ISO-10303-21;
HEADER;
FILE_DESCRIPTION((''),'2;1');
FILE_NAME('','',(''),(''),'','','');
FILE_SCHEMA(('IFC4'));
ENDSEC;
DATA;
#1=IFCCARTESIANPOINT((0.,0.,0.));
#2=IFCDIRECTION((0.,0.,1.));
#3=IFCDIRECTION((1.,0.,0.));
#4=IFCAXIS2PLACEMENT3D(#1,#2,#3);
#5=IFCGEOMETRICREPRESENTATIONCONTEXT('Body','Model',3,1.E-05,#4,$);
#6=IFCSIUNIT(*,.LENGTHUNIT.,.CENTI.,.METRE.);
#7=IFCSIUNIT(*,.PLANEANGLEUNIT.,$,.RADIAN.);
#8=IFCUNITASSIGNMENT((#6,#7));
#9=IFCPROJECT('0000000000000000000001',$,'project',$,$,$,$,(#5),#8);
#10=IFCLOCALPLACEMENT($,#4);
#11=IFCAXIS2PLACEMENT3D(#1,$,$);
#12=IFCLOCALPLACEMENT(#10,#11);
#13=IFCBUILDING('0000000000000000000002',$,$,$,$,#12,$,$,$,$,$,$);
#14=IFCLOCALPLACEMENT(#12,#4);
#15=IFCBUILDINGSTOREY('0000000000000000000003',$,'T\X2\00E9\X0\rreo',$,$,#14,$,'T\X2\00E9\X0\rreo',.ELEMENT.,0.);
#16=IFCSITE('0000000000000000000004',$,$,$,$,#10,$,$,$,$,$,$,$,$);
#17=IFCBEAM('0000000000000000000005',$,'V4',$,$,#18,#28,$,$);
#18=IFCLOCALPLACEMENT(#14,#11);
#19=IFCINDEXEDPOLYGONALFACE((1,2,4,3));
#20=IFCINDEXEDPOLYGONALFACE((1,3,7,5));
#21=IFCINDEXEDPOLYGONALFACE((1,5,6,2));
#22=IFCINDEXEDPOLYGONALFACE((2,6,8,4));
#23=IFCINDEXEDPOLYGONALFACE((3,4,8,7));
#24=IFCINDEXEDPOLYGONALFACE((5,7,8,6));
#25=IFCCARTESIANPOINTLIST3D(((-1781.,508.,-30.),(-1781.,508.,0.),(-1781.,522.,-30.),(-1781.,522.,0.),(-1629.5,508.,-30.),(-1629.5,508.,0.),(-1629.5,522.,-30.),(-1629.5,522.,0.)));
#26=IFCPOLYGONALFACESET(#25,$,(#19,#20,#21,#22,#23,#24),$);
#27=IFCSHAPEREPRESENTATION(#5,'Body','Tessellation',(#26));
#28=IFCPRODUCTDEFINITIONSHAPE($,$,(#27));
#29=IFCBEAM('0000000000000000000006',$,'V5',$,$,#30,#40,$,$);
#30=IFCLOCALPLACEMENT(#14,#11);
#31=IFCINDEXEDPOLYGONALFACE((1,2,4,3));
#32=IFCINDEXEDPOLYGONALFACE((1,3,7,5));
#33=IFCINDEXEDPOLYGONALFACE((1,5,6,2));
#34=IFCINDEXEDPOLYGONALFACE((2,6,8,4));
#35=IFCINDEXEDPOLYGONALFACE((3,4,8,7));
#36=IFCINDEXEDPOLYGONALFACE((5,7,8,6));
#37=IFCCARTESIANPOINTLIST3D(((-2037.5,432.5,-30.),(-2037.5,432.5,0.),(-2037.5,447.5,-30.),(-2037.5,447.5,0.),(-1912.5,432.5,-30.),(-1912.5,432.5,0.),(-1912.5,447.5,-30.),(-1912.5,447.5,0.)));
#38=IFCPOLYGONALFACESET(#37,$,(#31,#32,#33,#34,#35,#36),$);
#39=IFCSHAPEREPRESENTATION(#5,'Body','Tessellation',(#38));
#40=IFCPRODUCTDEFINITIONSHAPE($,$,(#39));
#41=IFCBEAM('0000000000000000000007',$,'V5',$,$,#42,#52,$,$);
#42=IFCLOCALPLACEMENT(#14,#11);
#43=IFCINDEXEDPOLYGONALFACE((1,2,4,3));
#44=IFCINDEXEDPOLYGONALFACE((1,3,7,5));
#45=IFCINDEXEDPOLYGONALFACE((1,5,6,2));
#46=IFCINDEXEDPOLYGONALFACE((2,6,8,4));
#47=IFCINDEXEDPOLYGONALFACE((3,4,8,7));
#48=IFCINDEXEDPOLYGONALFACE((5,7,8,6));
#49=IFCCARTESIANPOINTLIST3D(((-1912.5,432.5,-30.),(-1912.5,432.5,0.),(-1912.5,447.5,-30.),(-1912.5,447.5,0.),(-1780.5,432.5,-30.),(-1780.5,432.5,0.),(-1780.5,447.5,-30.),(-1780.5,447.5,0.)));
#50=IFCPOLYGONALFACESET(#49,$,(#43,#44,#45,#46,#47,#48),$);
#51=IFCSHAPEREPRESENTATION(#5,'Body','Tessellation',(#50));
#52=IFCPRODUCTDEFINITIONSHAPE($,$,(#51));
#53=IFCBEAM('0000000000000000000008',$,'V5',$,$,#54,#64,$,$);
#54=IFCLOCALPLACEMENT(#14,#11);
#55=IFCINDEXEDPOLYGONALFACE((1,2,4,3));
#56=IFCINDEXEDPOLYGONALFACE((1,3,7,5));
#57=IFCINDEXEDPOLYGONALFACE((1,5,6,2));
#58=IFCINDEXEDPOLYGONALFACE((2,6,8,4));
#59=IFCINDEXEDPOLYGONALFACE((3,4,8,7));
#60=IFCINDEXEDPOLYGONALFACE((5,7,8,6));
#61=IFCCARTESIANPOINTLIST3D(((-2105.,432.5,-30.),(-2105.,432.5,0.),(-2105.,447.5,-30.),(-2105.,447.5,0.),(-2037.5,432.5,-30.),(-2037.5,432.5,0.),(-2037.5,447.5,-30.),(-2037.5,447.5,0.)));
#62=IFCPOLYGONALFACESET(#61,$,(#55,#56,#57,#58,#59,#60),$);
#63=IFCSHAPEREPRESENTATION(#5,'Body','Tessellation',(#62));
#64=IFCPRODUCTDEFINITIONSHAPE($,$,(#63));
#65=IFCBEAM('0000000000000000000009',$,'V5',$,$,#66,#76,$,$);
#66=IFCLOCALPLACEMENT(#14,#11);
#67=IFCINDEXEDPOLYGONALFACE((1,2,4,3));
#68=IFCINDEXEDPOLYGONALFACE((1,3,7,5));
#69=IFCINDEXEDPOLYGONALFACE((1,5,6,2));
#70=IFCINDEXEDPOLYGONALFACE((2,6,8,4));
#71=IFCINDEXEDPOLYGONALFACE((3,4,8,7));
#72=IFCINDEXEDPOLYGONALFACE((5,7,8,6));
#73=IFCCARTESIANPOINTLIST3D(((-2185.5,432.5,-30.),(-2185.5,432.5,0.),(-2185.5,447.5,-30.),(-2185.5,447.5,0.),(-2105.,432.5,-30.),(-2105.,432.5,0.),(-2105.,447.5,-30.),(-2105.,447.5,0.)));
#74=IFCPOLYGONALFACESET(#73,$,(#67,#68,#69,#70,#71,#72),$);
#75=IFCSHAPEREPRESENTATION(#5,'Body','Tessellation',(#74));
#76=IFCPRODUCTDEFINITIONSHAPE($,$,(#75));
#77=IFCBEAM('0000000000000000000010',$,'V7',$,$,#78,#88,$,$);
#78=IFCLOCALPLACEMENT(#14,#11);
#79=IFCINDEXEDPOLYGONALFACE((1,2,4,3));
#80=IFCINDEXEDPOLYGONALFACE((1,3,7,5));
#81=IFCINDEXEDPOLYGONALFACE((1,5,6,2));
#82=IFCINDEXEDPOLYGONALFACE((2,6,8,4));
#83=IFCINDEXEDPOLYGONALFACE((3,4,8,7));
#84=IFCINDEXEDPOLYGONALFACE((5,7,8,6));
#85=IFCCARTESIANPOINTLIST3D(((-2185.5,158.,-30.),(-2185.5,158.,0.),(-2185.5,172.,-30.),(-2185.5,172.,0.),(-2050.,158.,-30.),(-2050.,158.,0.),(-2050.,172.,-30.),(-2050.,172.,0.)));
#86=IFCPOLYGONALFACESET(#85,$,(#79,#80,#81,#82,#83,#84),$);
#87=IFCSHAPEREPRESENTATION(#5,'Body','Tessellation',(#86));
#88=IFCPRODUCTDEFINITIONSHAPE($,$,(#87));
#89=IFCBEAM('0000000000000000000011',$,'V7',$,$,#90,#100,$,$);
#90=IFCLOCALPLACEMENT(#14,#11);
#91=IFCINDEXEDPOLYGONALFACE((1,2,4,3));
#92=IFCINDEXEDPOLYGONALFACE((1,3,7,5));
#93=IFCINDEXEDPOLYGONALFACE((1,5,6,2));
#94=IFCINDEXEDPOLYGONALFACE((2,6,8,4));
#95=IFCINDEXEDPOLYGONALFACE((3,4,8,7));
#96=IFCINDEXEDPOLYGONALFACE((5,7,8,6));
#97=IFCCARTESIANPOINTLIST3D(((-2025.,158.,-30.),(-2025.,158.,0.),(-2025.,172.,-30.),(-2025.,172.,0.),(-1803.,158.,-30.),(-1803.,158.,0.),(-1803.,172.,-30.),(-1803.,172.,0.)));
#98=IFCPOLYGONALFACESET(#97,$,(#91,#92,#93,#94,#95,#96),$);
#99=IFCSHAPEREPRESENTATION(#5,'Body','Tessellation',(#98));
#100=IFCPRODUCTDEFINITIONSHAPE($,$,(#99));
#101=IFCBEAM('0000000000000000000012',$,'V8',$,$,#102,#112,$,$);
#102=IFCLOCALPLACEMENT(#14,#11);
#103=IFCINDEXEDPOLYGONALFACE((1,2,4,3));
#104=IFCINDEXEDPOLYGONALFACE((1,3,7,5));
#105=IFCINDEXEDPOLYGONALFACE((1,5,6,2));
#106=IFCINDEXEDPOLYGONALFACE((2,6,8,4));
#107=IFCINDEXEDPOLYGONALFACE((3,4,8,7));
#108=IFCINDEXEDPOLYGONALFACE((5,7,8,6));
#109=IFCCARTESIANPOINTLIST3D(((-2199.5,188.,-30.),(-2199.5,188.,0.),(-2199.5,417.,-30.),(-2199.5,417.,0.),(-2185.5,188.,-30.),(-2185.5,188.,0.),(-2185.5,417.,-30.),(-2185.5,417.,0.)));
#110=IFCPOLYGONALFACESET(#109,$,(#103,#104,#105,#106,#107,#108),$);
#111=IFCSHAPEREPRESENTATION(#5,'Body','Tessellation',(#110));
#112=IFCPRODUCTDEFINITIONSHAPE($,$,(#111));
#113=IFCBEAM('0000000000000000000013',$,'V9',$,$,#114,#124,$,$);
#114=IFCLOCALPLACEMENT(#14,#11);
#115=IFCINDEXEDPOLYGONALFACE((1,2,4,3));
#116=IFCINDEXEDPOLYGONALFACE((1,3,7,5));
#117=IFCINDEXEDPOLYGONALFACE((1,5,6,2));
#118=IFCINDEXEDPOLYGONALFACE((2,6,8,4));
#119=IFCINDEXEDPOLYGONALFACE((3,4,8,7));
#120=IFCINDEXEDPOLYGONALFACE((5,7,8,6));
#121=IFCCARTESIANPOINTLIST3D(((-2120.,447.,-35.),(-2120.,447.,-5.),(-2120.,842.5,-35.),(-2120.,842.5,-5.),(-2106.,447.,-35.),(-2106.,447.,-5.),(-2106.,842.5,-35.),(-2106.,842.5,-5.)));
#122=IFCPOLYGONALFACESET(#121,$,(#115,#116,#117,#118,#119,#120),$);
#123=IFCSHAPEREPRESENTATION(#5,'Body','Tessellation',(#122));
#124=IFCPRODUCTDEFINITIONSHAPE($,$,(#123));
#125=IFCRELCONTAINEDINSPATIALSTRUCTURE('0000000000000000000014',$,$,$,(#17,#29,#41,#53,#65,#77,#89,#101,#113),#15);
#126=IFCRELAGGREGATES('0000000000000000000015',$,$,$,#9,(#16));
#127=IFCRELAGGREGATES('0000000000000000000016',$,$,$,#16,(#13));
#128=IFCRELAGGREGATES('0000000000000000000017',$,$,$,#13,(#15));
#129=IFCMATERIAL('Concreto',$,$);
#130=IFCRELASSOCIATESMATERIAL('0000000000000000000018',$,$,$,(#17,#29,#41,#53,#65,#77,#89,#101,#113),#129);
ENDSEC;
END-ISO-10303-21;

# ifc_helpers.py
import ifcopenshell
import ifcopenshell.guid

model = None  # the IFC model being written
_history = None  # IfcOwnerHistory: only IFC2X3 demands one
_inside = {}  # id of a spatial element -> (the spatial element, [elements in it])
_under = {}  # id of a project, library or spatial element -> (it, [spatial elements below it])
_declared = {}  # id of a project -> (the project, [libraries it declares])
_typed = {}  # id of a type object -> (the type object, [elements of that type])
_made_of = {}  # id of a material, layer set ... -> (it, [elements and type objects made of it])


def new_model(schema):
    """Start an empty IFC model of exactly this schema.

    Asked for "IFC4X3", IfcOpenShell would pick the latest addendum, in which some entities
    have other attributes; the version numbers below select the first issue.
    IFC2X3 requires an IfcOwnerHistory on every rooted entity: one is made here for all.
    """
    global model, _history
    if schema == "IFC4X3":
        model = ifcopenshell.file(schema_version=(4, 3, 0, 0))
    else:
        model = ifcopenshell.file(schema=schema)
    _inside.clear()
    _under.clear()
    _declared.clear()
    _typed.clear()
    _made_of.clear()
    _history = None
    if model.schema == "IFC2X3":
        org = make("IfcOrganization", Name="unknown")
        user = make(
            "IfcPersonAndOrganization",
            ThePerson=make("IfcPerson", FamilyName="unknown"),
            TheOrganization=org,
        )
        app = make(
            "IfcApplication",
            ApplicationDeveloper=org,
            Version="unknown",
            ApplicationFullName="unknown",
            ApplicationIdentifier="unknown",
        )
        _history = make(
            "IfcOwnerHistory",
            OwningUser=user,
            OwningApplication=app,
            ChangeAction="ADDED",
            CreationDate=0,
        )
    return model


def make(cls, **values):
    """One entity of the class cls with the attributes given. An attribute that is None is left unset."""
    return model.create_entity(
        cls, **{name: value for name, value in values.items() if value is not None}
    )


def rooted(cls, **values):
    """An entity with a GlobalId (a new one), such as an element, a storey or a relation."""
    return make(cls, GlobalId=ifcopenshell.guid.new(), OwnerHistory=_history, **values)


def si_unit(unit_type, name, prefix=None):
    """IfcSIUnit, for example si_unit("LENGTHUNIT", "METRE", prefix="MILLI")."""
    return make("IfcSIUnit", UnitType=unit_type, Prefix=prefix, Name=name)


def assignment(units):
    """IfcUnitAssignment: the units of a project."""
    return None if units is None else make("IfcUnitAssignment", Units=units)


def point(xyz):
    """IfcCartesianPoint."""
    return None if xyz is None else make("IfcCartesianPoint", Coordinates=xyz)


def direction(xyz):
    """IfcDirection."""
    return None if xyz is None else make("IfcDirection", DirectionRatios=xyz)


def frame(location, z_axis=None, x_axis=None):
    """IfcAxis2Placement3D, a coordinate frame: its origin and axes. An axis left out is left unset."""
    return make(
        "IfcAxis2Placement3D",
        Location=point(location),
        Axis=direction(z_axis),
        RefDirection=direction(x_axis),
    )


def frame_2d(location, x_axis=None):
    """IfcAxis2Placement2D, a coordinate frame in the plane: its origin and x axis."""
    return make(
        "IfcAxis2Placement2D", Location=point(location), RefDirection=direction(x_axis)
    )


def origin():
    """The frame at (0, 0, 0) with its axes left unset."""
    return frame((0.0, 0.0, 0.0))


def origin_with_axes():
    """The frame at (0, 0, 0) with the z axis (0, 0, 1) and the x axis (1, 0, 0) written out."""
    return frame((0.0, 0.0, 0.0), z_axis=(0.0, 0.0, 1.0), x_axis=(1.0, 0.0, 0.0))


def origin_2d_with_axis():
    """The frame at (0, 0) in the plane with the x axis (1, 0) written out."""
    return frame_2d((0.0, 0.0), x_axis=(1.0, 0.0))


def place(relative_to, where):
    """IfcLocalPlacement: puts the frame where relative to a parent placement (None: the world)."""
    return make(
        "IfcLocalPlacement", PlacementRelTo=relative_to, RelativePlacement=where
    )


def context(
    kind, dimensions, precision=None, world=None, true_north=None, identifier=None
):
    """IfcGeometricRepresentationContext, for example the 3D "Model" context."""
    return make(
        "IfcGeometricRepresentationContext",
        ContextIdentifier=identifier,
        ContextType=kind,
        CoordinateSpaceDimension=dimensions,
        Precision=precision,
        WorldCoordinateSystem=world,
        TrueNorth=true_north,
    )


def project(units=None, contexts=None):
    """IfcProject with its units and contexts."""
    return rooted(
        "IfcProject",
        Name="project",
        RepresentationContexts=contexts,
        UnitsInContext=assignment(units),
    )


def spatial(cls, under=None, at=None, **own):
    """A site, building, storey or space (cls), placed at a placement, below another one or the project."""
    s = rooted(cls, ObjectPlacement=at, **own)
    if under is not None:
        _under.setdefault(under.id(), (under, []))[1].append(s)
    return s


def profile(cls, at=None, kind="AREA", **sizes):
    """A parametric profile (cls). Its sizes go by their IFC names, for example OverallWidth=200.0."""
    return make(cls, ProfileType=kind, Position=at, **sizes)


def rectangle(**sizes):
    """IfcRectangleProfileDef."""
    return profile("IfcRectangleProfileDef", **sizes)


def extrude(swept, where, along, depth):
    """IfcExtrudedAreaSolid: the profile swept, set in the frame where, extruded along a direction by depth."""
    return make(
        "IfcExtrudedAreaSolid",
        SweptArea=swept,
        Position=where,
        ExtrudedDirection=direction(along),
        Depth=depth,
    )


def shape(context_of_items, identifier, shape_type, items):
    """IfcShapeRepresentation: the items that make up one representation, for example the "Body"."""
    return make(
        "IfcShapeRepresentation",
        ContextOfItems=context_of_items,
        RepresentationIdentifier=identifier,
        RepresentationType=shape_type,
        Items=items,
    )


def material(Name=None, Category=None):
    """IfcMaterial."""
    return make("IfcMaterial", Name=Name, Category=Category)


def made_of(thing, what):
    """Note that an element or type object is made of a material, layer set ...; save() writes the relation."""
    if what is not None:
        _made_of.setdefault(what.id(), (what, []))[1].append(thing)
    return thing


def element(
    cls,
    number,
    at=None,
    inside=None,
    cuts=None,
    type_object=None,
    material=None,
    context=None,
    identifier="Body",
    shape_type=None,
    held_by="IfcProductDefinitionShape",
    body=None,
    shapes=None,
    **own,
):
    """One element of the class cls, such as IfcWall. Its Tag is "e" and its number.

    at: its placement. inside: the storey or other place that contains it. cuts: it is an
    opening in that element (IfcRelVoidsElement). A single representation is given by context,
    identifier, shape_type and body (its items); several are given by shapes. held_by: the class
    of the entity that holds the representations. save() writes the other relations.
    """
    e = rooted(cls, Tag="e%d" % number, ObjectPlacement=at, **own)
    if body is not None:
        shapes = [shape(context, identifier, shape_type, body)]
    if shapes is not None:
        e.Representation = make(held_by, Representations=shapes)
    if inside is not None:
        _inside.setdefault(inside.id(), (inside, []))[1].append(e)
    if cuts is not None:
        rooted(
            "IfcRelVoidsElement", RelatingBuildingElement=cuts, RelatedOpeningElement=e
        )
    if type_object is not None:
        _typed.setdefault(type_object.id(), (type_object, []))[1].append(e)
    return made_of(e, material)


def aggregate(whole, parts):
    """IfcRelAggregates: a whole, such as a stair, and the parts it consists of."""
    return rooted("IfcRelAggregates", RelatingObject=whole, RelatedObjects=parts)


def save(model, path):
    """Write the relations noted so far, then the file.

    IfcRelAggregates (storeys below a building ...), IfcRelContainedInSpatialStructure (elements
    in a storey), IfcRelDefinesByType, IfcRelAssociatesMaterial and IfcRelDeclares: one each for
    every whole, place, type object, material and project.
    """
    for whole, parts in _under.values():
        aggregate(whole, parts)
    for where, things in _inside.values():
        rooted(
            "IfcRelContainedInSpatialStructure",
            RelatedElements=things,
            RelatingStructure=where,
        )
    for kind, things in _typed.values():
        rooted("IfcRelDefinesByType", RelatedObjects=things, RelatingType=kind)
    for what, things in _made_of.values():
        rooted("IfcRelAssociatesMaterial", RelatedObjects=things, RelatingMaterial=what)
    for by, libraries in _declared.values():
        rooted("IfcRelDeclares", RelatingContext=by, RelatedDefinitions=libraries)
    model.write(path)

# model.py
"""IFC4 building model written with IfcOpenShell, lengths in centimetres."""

from ifc_helpers import new_model, si_unit, frame, origin, origin_with_axes, origin_2d_with_axis, place, context, project, spatial, rectangle, extrude, material, element, save


model = new_model("IFC4")

# Units and contexts
model_context = context("Model", 3, precision=1e-05, world=origin_with_axes(), identifier="Body")
ifc_project = project(units=[si_unit("LENGTHUNIT", "METRE", prefix="CENTI"), si_unit("PLANEANGLEUNIT", "RADIAN")], contexts=[model_context])

# Site, building, storey
site_placement = place(None, origin_with_axes())
site = spatial("IfcSite", under=ifc_project, at=site_placement)
building_placement = place(site_placement, origin())
building = spatial("IfcBuilding", under=site, at=building_placement)
storey_placement = place(building_placement, origin_with_axes())
storey = spatial("IfcBuildingStorey", under=building, at=storey_placement, Name="Térreo", LongName="Térreo", CompositionType="ELEMENT", Elevation=0.0)

# Shared definitions
ifc_material = material(Name="Concreto")

# Beams
beam_1_placement = place(storey_placement, frame((-1705.25, 515.0, 0.0), z_axis=(0.0, 0.0, 1.0), x_axis=(1.0, 0.0, 0.0)))
element("IfcBeam", 1, at=beam_1_placement, inside=storey, material=ifc_material, Name="V4", context=model_context, shape_type="SolidModel", body=[
    extrude(rectangle(XDim=14.0, YDim=30.0, at=origin_2d_with_axis()), frame((-75.75, 0.0, -15.0), z_axis=(1.0, 0.0, 0.0), x_axis=(0.0, -1.0, 0.0)), (0.0, 0.0, 1.0), 151.5),
])
beam_2_placement = place(storey_placement, frame((-1975.0, 440.0, 0.0), z_axis=(0.0, 0.0, 1.0), x_axis=(1.0, 0.0, 0.0)))
element("IfcBeam", 2, at=beam_2_placement, inside=storey, material=ifc_material, Name="V5", context=model_context, shape_type="SolidModel", body=[
    extrude(rectangle(XDim=15.0, YDim=30.0, at=origin_2d_with_axis()), frame((-62.5, 0.0, -15.0), z_axis=(1.0, 0.0, 0.0), x_axis=(0.0, -1.0, 0.0)), (0.0, 0.0, 1.0), 125.0),
])
beam_3_placement = place(storey_placement, frame((-1846.5, 440.0, 0.0), z_axis=(0.0, 0.0, 1.0), x_axis=(1.0, 0.0, 0.0)))
element("IfcBeam", 3, at=beam_3_placement, inside=storey, material=ifc_material, Name="V5", context=model_context, shape_type="SolidModel", body=[
    extrude(rectangle(XDim=15.0, YDim=30.0, at=origin_2d_with_axis()), frame((-66.0, 0.0, -15.0), z_axis=(1.0, 0.0, 0.0), x_axis=(0.0, -1.0, 0.0)), (0.0, 0.0, 1.0), 132.0),
])
beam_4_placement = place(storey_placement, frame((-2071.25, 440.0, 0.0), z_axis=(0.0, 0.0, 1.0), x_axis=(1.0, 0.0, 0.0)))
element("IfcBeam", 4, at=beam_4_placement, inside=storey, material=ifc_material, Name="V5", context=model_context, shape_type="SolidModel", body=[
    extrude(rectangle(XDim=15.0, YDim=30.0, at=origin_2d_with_axis()), frame((-33.75, 0.0, -15.0), z_axis=(1.0, 0.0, 0.0), x_axis=(0.0, -1.0, 0.0)), (0.0, 0.0, 1.0), 67.5),
])
beam_5_placement = place(storey_placement, frame((-2145.25, 440.0, 0.0), z_axis=(0.0, 0.0, 1.0), x_axis=(1.0, 0.0, 0.0)))
element("IfcBeam", 5, at=beam_5_placement, inside=storey, material=ifc_material, Name="V5", context=model_context, shape_type="SolidModel", body=[
    extrude(rectangle(XDim=15.0, YDim=30.0, at=origin_2d_with_axis()), frame((-40.25, 0.0, -15.0), z_axis=(1.0, 0.0, 0.0), x_axis=(0.0, -1.0, 0.0)), (0.0, 0.0, 1.0), 80.5),
])
beam_6_placement = place(storey_placement, frame((-2117.75, 165.0, 0.0), z_axis=(0.0, 0.0, 1.0), x_axis=(1.0, 0.0, 0.0)))
element("IfcBeam", 6, at=beam_6_placement, inside=storey, material=ifc_material, Name="V7", context=model_context, shape_type="SolidModel", body=[
    extrude(rectangle(XDim=14.0, YDim=30.0, at=origin_2d_with_axis()), frame((-67.75, 0.0, -15.0), z_axis=(1.0, 0.0, 0.0), x_axis=(0.0, -1.0, 0.0)), (0.0, 0.0, 1.0), 135.5),
])
beam_7_placement = place(storey_placement, frame((-1914.0, 165.0, 0.0), z_axis=(0.0, 0.0, 1.0), x_axis=(1.0, 0.0, 0.0)))
element("IfcBeam", 7, at=beam_7_placement, inside=storey, material=ifc_material, Name="V7", context=model_context, shape_type="SolidModel", body=[
    extrude(rectangle(XDim=14.0, YDim=30.0, at=origin_2d_with_axis()), frame((-111.0, 0.0, -15.0), z_axis=(1.0, 0.0, 0.0), x_axis=(0.0, -1.0, 0.0)), (0.0, 0.0, 1.0), 222.0),
])
beam_8_placement = place(storey_placement, frame((-2192.5, 302.5, 0.0), z_axis=(0.0, 0.0, 1.0), x_axis=(1.0, 0.0, 0.0)))
element("IfcBeam", 8, at=beam_8_placement, inside=storey, material=ifc_material, Name="V8", context=model_context, shape_type="SolidModel", body=[
    extrude(rectangle(XDim=14.0, YDim=30.0, at=origin_2d_with_axis()), frame((0.0, -114.5, -15.0), z_axis=(0.0, 1.0, 0.0), x_axis=(-1.0, 0.0, 0.0)), (0.0, 0.0, 1.0), 229.0),
])
beam_9_placement = place(storey_placement, frame((-2113.0, 644.75, -5.0), z_axis=(0.0, 0.0, 1.0), x_axis=(1.0, 0.0, 0.0)))
element("IfcBeam", 9, at=beam_9_placement, inside=storey, material=ifc_material, Name="V9", context=model_context, shape_type="SolidModel", body=[
    extrude(rectangle(XDim=14.0, YDim=30.0, at=origin_2d_with_axis()), frame((0.0, -197.75, -15.0), z_axis=(0.0, 1.0, 0.0), x_axis=(-1.0, 0.0, 0.0)), (0.0, 0.0, 1.0), 395.5),
])

save(model, "model.ifc")
